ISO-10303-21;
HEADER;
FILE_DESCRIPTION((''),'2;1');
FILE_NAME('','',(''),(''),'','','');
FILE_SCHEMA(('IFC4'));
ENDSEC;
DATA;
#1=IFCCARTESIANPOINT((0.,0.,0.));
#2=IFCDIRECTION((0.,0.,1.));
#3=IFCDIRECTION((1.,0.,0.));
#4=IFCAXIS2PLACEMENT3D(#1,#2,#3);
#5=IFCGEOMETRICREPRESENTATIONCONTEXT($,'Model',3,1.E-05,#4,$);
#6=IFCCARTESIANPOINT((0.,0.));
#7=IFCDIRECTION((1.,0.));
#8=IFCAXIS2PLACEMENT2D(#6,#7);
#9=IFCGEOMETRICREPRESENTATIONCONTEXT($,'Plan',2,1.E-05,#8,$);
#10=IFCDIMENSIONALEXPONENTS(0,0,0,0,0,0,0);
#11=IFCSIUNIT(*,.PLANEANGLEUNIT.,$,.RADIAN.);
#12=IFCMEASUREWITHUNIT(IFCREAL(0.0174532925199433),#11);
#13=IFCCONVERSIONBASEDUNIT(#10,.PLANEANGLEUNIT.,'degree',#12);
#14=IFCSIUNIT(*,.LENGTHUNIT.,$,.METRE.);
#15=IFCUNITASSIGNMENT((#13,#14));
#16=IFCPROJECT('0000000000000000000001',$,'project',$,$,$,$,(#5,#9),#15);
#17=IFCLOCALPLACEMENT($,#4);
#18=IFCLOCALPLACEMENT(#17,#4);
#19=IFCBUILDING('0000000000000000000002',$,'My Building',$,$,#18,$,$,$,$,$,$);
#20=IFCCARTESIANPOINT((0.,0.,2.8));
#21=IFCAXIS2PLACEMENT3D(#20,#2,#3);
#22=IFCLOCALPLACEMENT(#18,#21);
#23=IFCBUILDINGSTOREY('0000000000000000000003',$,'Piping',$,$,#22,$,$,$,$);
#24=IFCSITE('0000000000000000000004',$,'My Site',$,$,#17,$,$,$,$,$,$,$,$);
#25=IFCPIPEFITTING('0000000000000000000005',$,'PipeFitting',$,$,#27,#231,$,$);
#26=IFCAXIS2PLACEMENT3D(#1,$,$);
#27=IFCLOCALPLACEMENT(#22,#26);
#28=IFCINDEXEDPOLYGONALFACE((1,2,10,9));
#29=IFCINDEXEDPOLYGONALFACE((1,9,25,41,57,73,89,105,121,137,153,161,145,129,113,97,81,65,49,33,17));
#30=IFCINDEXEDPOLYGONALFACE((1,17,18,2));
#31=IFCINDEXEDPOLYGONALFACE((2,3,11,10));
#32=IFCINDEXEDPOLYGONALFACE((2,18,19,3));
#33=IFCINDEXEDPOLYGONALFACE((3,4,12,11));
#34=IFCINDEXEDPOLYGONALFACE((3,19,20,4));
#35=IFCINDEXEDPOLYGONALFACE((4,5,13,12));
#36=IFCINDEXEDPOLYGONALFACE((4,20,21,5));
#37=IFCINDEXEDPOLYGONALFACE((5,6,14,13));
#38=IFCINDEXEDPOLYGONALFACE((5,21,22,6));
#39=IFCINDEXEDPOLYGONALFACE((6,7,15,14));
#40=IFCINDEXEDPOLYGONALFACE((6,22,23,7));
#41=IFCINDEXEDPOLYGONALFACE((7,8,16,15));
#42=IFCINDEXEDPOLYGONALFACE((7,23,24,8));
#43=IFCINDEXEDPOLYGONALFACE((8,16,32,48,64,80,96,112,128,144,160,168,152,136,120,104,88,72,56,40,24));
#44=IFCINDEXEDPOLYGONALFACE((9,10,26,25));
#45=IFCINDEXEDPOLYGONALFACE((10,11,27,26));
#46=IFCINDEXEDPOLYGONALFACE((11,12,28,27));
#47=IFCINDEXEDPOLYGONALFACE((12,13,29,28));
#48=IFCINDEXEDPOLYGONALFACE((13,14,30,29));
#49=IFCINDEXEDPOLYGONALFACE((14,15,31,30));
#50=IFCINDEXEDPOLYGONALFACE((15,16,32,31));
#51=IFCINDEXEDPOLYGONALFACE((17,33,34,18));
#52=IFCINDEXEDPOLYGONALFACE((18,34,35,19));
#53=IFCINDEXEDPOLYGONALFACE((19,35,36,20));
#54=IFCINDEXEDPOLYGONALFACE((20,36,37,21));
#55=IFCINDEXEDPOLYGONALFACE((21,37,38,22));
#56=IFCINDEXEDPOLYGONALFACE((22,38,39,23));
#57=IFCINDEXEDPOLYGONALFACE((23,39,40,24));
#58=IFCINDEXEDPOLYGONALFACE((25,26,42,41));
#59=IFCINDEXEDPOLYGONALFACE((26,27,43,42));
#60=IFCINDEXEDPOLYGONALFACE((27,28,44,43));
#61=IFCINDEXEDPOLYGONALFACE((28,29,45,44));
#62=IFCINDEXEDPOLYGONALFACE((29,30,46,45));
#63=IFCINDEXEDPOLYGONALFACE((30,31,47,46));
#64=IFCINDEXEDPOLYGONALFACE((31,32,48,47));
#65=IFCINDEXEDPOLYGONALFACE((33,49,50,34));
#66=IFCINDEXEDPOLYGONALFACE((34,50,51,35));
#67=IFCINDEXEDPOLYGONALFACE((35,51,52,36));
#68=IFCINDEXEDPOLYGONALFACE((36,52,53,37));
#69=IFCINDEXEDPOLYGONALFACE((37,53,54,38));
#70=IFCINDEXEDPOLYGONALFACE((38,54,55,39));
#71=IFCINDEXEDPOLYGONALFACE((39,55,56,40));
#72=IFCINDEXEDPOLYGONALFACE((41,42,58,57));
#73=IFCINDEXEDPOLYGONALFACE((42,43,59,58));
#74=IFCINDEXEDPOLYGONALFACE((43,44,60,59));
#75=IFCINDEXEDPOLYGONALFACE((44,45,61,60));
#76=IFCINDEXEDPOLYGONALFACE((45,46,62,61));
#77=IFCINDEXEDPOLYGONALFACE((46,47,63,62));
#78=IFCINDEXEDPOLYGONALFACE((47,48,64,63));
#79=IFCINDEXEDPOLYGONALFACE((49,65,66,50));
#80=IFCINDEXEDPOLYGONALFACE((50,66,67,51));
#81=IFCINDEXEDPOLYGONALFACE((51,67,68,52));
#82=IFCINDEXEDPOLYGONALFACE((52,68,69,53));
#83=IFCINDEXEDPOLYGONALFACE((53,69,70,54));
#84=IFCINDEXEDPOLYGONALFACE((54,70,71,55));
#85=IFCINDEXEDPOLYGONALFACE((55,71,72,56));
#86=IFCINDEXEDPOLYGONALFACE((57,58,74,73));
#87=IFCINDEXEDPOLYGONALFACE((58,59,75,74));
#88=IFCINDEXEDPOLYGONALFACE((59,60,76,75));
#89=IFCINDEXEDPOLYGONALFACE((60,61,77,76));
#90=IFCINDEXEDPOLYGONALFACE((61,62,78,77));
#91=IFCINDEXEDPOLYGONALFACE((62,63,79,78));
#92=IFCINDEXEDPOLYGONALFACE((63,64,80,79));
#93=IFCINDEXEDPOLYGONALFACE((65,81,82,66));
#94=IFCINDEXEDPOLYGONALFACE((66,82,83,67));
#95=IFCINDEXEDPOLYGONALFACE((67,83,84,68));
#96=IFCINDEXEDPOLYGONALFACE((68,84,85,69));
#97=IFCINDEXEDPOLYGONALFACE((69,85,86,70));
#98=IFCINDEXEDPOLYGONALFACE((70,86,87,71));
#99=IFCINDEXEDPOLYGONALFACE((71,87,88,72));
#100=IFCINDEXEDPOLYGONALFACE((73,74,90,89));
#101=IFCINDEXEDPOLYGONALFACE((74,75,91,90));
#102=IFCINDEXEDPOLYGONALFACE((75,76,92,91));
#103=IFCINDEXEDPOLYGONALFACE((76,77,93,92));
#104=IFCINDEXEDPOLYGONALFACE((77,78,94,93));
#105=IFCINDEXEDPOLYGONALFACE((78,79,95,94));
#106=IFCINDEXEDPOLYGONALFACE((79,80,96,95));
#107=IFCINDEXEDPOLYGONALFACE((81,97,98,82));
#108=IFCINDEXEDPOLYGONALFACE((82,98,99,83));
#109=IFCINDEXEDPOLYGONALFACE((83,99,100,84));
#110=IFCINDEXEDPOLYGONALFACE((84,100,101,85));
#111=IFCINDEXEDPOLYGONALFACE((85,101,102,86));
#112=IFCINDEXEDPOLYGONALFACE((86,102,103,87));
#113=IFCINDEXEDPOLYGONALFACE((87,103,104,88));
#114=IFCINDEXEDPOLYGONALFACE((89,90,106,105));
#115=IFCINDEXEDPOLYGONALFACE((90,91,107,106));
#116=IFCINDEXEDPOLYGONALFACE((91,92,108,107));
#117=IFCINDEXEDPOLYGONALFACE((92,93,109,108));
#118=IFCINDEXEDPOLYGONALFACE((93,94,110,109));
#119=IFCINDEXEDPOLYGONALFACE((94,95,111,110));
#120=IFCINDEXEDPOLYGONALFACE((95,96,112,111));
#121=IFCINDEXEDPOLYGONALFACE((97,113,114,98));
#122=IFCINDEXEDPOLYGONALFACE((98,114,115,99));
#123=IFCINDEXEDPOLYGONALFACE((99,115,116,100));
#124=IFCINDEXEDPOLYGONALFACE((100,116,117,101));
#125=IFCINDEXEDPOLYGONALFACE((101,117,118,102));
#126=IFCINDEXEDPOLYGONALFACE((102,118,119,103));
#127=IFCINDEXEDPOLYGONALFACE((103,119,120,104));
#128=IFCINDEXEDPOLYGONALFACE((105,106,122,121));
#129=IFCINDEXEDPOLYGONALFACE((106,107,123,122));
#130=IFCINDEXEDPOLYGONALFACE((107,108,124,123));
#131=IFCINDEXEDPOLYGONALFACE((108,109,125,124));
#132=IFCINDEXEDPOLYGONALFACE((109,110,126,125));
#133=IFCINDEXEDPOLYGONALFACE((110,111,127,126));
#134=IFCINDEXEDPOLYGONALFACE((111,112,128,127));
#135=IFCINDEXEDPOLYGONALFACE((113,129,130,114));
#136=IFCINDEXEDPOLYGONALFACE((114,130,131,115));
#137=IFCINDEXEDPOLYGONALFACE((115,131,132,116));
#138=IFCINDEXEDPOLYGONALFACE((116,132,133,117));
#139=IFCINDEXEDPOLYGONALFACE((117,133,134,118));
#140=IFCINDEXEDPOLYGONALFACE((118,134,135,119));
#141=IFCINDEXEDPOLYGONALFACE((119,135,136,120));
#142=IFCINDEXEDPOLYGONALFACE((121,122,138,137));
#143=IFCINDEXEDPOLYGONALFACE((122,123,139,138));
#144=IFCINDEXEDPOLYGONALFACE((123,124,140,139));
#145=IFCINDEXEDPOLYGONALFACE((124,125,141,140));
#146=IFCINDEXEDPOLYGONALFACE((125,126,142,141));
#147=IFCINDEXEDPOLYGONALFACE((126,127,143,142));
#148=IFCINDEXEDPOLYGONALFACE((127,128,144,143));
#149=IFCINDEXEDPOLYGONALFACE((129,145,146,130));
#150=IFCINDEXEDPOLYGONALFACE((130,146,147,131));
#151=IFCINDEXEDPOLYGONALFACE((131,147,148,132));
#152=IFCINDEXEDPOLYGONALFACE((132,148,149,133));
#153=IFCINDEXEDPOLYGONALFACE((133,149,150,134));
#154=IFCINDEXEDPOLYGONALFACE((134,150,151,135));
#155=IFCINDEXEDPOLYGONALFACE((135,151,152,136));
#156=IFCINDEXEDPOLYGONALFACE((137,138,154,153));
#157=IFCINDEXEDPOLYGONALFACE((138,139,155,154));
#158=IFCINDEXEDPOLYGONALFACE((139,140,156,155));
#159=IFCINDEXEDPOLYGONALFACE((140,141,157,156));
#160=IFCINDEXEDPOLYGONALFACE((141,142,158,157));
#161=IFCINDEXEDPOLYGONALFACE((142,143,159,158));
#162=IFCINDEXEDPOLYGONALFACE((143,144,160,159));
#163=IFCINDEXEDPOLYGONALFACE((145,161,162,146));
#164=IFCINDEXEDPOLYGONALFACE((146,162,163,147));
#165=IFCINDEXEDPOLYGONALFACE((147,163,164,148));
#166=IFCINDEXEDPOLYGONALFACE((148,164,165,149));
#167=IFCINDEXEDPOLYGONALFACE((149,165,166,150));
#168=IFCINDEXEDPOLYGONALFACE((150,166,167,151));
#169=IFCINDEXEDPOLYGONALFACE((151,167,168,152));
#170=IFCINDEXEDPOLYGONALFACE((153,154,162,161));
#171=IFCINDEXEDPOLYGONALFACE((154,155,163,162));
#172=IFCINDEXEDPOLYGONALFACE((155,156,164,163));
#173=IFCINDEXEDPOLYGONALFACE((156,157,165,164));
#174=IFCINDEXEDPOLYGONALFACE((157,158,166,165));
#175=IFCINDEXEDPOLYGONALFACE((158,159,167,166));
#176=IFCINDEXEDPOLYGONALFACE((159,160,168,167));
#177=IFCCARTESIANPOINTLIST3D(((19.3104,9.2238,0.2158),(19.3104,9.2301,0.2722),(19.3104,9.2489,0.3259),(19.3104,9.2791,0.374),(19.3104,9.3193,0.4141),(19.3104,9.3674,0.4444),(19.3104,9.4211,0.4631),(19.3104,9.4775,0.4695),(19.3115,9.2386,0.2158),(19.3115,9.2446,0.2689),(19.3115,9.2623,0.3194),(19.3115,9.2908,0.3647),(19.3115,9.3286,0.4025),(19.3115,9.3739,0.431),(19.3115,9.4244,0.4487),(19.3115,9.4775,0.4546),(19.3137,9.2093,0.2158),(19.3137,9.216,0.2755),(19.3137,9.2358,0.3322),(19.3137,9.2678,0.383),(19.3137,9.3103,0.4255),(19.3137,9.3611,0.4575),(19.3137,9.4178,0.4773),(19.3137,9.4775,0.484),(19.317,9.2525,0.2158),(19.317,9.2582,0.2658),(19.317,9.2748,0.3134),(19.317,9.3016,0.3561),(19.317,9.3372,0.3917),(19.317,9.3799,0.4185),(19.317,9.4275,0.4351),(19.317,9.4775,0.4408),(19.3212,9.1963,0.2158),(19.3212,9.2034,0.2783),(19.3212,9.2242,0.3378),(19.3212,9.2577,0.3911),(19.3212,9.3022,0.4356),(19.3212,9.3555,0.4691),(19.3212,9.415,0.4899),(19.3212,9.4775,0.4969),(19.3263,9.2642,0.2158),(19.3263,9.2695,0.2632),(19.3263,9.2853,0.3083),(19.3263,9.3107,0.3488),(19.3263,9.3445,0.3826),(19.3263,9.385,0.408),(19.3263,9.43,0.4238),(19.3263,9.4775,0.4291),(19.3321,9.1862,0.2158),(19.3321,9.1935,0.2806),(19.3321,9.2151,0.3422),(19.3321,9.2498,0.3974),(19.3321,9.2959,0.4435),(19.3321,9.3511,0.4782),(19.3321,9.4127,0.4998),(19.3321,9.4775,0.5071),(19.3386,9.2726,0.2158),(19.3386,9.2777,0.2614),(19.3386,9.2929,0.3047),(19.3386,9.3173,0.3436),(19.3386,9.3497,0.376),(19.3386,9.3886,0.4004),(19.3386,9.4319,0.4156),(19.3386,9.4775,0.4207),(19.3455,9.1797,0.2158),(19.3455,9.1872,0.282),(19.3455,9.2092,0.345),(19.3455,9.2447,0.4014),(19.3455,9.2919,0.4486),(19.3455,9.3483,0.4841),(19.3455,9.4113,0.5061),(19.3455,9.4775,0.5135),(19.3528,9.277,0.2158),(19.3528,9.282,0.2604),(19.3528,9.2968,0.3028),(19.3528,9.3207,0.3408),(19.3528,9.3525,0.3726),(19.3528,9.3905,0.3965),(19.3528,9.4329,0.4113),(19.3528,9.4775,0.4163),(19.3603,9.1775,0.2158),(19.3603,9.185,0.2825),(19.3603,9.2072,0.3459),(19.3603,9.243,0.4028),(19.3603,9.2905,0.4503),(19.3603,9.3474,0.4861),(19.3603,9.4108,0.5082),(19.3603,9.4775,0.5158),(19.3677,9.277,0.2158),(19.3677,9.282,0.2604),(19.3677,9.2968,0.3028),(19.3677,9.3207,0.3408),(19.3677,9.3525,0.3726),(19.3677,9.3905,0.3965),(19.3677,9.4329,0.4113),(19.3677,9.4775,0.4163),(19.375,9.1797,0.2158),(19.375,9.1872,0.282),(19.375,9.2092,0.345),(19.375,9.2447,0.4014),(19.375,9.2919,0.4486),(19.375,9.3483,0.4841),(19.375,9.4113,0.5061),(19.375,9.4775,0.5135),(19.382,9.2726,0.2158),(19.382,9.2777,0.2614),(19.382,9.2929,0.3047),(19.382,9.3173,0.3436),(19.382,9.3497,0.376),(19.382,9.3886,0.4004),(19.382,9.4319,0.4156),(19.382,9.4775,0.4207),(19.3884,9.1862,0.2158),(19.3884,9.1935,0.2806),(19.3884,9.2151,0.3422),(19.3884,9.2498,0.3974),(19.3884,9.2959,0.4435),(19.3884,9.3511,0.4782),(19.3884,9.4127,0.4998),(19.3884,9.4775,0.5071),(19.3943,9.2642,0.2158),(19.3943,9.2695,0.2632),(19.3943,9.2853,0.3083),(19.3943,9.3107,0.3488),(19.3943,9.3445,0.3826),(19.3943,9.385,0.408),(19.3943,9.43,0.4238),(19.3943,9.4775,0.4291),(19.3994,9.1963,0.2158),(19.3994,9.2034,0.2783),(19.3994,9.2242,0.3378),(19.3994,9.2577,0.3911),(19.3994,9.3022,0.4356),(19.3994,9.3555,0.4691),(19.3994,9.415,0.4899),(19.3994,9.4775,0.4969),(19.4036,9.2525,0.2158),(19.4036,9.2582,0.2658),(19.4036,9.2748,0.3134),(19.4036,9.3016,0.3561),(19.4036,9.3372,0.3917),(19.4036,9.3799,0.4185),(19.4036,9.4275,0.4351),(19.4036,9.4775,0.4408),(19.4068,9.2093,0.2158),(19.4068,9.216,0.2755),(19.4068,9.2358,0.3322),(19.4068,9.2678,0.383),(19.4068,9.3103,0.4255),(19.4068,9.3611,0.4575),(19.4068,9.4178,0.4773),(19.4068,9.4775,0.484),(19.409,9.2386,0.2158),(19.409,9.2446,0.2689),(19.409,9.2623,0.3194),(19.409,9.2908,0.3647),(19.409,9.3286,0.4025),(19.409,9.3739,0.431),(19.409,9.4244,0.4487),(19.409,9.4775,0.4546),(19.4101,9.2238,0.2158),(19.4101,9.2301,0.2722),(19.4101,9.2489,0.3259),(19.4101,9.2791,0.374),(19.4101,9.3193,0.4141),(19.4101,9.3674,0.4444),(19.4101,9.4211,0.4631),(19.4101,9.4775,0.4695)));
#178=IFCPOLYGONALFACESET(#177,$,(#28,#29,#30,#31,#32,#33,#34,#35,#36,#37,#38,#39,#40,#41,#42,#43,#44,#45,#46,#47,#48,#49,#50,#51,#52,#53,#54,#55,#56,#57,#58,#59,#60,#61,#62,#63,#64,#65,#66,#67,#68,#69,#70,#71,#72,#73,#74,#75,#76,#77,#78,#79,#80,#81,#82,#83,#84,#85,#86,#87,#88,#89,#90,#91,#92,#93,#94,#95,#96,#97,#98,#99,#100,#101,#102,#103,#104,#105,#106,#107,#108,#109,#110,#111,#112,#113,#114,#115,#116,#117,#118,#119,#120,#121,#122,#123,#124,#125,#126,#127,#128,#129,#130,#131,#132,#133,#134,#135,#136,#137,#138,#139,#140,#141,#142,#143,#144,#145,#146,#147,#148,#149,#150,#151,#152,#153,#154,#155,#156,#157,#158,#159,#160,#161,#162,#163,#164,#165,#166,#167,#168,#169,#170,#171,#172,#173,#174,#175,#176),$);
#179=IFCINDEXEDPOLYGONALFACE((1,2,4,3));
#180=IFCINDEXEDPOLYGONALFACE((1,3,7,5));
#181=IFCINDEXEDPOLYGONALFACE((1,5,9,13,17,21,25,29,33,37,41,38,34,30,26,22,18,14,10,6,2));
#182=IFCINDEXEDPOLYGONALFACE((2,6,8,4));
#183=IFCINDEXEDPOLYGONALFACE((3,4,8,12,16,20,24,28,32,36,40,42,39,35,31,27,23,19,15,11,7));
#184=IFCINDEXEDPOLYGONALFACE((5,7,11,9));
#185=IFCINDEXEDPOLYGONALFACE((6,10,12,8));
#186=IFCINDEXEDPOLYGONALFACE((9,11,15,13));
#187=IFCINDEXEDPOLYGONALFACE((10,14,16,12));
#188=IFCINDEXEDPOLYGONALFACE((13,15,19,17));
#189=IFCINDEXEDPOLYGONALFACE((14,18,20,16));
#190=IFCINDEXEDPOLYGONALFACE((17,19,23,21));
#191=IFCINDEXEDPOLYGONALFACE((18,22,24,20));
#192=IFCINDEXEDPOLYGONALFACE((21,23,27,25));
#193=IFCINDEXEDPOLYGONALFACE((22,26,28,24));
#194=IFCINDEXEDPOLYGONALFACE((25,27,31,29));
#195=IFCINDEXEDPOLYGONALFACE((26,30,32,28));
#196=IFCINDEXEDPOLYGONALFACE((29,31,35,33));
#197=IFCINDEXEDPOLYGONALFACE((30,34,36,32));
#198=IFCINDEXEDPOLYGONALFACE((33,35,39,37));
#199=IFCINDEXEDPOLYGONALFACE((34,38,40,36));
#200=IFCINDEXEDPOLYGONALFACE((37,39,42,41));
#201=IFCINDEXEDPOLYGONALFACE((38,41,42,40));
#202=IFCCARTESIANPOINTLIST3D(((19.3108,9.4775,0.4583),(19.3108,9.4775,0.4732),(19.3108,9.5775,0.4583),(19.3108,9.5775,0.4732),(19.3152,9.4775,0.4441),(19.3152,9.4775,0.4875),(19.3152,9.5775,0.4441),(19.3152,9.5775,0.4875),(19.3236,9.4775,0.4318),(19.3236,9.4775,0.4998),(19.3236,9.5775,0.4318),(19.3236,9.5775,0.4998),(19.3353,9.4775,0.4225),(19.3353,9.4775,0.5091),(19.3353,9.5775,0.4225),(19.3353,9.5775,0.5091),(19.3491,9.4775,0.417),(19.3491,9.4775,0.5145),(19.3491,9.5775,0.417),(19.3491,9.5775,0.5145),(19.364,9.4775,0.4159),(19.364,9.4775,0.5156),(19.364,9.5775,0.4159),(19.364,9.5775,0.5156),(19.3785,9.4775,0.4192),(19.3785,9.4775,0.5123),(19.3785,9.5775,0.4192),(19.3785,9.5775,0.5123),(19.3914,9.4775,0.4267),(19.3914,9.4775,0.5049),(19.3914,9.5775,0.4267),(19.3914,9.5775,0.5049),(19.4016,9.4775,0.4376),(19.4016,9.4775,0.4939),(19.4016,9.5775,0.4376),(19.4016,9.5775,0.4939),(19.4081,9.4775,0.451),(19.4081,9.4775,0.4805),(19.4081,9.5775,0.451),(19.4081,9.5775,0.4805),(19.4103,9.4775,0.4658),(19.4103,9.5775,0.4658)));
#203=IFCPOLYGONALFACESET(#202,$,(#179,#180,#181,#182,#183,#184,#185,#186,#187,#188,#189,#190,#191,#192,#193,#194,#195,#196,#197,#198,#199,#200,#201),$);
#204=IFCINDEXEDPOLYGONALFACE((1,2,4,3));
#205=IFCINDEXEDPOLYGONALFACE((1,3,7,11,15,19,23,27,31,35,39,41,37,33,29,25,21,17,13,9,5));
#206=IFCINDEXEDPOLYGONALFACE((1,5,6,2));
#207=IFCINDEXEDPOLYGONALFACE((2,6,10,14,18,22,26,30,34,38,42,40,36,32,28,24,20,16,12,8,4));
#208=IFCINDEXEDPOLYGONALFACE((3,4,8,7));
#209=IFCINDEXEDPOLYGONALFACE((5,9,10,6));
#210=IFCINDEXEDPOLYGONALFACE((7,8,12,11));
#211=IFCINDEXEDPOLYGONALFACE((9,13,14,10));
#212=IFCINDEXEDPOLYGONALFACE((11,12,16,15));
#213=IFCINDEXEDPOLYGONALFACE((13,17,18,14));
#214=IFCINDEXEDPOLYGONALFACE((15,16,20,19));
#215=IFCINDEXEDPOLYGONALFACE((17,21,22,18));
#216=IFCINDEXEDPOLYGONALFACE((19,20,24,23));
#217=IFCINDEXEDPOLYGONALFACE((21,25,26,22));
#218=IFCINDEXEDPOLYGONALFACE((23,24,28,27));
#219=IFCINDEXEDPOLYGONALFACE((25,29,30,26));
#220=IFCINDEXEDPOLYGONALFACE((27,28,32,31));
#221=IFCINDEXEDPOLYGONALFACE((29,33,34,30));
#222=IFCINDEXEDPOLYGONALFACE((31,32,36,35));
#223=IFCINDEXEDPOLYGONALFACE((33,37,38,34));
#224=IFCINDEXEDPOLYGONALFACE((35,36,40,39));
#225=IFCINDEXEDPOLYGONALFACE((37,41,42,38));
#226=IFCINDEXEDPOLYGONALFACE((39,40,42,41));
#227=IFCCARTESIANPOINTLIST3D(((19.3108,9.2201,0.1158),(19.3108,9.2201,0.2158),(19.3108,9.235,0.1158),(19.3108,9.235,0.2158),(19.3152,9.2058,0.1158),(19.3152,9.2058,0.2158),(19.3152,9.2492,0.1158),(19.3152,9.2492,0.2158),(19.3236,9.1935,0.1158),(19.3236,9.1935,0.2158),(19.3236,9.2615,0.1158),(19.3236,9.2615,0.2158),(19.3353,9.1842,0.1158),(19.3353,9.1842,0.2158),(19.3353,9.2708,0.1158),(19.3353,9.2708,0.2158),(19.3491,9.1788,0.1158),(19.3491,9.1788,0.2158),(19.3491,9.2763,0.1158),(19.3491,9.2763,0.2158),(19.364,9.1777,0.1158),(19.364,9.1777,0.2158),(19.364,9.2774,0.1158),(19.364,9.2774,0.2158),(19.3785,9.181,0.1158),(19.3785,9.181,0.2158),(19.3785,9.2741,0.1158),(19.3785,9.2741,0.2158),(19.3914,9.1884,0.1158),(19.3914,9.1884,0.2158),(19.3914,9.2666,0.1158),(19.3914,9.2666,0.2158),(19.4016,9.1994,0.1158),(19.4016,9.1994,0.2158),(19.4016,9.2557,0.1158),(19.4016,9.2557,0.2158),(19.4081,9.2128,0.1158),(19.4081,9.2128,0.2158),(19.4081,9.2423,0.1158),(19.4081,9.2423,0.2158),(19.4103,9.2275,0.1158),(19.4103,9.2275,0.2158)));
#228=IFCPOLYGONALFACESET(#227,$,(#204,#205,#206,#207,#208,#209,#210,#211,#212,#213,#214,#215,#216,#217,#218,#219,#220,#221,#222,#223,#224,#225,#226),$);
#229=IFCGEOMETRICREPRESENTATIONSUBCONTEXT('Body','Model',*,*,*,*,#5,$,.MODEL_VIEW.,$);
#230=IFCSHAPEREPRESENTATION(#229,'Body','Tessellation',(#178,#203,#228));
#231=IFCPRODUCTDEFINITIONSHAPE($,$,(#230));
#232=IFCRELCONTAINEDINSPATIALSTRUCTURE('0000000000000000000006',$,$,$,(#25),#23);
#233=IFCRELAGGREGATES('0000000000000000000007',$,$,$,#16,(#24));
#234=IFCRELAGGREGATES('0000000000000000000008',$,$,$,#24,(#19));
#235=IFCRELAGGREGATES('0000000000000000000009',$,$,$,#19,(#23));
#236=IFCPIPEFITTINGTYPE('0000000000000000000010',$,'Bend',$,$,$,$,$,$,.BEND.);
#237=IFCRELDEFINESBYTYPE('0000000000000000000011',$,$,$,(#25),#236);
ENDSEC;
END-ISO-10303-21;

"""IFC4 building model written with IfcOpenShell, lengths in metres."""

from ifc_helpers import new_model, entity, si_unit, converted_unit, frame, origin_with_axes, origin_2d_with_axis, place, context, subcontext, project, spatial, circle, extrude, source, transform, mapped, type_object, type_shapes, element, save


model = new_model("IFC4")

# Units and contexts
model_context = context("Model", 3, precision=1e-05, world=origin_with_axes())
plan_context = context("Plan", 2, precision=1e-05, world=origin_2d_with_axis())
body_context = subcontext(model_context, "Body", "Model", "MODEL_VIEW")
ifc_project = project(units=[converted_unit("PLANEANGLEUNIT", "degree", entity("IfcReal", 0.0174532925199433), si_unit("PLANEANGLEUNIT", "RADIAN"), dimensions=[0, 0, 0, 0, 0, 0, 0]), si_unit("LENGTHUNIT", "METRE")], contexts=[model_context, plan_context])

# Site, building, storey
site_placement = place(None, origin_with_axes())
site = spatial("IfcSite", under=ifc_project, at=site_placement, Name="My Site")
building_placement = place(site_placement, origin_with_axes())
building = spatial("IfcBuilding", under=site, at=building_placement, Name="My Building")
storey_placement = place(building_placement, frame((0.0, 0.0, 2.8), z_axis=(0.0, 0.0, 1.0), x_axis=(1.0, 0.0, 0.0)))
storey = spatial("IfcBuildingStorey", under=building, at=storey_placement, Name="Piping")

# Pipe fitting
pipe_fitting_type_1 = type_object("IfcPipeFittingType", Name="Bend", PredefinedType="BEND")
shared_shape_1 = source(origin_with_axes(), body_context, "Body", "SolidModel", [
    entity("IfcSweptDiskSolid", entity("IfcIndexedPolyCurve", entity("IfcCartesianPointList3D", [[0.0, 0.0, 0.1], [0.0, -0.0732, 0.2768], [0.0, -0.25, 0.35]]), [entity("IfcArcIndex", [1, 2, 3])]), 0.05),
    extrude(circle(Radius=0.05), origin_with_axes(), (0.0, 0.0, 1.0), 0.1),
    extrude(circle(Radius=0.05), frame((0.0, -0.25, 0.35), z_axis=(0.0, -1.0, 0.0), x_axis=(1.0, 0.0, 0.0)), (0.0, 0.0, 1.0), 0.1),
])
type_shapes(pipe_fitting_type_1, [shared_shape_1])
for number, where, z_axis, x_axis, name in (
    (1, (19.3603, 9.5775, 0.4658), (0.0, -1.0, 0.0), (1.0, 0.0, 0.0), "PipeFitting"),
):
    element("IfcPipeFitting", number, at=place(storey_placement, frame(where, z_axis=z_axis, x_axis=x_axis)), inside=storey, type_object=pipe_fitting_type_1, Name=name, context=body_context, shape_type="MappedRepresentation", body=[
        mapped(shared_shape_1, transform((0.0, 0.0, 0.0), x_axis=(1.0, 0.0, 0.0), y_axis=(0.0, 1.0, 0.0), z_axis=(0.0, 0.0, 1.0), scale=1.0)),
    ])

save(model, "model.ifc")
